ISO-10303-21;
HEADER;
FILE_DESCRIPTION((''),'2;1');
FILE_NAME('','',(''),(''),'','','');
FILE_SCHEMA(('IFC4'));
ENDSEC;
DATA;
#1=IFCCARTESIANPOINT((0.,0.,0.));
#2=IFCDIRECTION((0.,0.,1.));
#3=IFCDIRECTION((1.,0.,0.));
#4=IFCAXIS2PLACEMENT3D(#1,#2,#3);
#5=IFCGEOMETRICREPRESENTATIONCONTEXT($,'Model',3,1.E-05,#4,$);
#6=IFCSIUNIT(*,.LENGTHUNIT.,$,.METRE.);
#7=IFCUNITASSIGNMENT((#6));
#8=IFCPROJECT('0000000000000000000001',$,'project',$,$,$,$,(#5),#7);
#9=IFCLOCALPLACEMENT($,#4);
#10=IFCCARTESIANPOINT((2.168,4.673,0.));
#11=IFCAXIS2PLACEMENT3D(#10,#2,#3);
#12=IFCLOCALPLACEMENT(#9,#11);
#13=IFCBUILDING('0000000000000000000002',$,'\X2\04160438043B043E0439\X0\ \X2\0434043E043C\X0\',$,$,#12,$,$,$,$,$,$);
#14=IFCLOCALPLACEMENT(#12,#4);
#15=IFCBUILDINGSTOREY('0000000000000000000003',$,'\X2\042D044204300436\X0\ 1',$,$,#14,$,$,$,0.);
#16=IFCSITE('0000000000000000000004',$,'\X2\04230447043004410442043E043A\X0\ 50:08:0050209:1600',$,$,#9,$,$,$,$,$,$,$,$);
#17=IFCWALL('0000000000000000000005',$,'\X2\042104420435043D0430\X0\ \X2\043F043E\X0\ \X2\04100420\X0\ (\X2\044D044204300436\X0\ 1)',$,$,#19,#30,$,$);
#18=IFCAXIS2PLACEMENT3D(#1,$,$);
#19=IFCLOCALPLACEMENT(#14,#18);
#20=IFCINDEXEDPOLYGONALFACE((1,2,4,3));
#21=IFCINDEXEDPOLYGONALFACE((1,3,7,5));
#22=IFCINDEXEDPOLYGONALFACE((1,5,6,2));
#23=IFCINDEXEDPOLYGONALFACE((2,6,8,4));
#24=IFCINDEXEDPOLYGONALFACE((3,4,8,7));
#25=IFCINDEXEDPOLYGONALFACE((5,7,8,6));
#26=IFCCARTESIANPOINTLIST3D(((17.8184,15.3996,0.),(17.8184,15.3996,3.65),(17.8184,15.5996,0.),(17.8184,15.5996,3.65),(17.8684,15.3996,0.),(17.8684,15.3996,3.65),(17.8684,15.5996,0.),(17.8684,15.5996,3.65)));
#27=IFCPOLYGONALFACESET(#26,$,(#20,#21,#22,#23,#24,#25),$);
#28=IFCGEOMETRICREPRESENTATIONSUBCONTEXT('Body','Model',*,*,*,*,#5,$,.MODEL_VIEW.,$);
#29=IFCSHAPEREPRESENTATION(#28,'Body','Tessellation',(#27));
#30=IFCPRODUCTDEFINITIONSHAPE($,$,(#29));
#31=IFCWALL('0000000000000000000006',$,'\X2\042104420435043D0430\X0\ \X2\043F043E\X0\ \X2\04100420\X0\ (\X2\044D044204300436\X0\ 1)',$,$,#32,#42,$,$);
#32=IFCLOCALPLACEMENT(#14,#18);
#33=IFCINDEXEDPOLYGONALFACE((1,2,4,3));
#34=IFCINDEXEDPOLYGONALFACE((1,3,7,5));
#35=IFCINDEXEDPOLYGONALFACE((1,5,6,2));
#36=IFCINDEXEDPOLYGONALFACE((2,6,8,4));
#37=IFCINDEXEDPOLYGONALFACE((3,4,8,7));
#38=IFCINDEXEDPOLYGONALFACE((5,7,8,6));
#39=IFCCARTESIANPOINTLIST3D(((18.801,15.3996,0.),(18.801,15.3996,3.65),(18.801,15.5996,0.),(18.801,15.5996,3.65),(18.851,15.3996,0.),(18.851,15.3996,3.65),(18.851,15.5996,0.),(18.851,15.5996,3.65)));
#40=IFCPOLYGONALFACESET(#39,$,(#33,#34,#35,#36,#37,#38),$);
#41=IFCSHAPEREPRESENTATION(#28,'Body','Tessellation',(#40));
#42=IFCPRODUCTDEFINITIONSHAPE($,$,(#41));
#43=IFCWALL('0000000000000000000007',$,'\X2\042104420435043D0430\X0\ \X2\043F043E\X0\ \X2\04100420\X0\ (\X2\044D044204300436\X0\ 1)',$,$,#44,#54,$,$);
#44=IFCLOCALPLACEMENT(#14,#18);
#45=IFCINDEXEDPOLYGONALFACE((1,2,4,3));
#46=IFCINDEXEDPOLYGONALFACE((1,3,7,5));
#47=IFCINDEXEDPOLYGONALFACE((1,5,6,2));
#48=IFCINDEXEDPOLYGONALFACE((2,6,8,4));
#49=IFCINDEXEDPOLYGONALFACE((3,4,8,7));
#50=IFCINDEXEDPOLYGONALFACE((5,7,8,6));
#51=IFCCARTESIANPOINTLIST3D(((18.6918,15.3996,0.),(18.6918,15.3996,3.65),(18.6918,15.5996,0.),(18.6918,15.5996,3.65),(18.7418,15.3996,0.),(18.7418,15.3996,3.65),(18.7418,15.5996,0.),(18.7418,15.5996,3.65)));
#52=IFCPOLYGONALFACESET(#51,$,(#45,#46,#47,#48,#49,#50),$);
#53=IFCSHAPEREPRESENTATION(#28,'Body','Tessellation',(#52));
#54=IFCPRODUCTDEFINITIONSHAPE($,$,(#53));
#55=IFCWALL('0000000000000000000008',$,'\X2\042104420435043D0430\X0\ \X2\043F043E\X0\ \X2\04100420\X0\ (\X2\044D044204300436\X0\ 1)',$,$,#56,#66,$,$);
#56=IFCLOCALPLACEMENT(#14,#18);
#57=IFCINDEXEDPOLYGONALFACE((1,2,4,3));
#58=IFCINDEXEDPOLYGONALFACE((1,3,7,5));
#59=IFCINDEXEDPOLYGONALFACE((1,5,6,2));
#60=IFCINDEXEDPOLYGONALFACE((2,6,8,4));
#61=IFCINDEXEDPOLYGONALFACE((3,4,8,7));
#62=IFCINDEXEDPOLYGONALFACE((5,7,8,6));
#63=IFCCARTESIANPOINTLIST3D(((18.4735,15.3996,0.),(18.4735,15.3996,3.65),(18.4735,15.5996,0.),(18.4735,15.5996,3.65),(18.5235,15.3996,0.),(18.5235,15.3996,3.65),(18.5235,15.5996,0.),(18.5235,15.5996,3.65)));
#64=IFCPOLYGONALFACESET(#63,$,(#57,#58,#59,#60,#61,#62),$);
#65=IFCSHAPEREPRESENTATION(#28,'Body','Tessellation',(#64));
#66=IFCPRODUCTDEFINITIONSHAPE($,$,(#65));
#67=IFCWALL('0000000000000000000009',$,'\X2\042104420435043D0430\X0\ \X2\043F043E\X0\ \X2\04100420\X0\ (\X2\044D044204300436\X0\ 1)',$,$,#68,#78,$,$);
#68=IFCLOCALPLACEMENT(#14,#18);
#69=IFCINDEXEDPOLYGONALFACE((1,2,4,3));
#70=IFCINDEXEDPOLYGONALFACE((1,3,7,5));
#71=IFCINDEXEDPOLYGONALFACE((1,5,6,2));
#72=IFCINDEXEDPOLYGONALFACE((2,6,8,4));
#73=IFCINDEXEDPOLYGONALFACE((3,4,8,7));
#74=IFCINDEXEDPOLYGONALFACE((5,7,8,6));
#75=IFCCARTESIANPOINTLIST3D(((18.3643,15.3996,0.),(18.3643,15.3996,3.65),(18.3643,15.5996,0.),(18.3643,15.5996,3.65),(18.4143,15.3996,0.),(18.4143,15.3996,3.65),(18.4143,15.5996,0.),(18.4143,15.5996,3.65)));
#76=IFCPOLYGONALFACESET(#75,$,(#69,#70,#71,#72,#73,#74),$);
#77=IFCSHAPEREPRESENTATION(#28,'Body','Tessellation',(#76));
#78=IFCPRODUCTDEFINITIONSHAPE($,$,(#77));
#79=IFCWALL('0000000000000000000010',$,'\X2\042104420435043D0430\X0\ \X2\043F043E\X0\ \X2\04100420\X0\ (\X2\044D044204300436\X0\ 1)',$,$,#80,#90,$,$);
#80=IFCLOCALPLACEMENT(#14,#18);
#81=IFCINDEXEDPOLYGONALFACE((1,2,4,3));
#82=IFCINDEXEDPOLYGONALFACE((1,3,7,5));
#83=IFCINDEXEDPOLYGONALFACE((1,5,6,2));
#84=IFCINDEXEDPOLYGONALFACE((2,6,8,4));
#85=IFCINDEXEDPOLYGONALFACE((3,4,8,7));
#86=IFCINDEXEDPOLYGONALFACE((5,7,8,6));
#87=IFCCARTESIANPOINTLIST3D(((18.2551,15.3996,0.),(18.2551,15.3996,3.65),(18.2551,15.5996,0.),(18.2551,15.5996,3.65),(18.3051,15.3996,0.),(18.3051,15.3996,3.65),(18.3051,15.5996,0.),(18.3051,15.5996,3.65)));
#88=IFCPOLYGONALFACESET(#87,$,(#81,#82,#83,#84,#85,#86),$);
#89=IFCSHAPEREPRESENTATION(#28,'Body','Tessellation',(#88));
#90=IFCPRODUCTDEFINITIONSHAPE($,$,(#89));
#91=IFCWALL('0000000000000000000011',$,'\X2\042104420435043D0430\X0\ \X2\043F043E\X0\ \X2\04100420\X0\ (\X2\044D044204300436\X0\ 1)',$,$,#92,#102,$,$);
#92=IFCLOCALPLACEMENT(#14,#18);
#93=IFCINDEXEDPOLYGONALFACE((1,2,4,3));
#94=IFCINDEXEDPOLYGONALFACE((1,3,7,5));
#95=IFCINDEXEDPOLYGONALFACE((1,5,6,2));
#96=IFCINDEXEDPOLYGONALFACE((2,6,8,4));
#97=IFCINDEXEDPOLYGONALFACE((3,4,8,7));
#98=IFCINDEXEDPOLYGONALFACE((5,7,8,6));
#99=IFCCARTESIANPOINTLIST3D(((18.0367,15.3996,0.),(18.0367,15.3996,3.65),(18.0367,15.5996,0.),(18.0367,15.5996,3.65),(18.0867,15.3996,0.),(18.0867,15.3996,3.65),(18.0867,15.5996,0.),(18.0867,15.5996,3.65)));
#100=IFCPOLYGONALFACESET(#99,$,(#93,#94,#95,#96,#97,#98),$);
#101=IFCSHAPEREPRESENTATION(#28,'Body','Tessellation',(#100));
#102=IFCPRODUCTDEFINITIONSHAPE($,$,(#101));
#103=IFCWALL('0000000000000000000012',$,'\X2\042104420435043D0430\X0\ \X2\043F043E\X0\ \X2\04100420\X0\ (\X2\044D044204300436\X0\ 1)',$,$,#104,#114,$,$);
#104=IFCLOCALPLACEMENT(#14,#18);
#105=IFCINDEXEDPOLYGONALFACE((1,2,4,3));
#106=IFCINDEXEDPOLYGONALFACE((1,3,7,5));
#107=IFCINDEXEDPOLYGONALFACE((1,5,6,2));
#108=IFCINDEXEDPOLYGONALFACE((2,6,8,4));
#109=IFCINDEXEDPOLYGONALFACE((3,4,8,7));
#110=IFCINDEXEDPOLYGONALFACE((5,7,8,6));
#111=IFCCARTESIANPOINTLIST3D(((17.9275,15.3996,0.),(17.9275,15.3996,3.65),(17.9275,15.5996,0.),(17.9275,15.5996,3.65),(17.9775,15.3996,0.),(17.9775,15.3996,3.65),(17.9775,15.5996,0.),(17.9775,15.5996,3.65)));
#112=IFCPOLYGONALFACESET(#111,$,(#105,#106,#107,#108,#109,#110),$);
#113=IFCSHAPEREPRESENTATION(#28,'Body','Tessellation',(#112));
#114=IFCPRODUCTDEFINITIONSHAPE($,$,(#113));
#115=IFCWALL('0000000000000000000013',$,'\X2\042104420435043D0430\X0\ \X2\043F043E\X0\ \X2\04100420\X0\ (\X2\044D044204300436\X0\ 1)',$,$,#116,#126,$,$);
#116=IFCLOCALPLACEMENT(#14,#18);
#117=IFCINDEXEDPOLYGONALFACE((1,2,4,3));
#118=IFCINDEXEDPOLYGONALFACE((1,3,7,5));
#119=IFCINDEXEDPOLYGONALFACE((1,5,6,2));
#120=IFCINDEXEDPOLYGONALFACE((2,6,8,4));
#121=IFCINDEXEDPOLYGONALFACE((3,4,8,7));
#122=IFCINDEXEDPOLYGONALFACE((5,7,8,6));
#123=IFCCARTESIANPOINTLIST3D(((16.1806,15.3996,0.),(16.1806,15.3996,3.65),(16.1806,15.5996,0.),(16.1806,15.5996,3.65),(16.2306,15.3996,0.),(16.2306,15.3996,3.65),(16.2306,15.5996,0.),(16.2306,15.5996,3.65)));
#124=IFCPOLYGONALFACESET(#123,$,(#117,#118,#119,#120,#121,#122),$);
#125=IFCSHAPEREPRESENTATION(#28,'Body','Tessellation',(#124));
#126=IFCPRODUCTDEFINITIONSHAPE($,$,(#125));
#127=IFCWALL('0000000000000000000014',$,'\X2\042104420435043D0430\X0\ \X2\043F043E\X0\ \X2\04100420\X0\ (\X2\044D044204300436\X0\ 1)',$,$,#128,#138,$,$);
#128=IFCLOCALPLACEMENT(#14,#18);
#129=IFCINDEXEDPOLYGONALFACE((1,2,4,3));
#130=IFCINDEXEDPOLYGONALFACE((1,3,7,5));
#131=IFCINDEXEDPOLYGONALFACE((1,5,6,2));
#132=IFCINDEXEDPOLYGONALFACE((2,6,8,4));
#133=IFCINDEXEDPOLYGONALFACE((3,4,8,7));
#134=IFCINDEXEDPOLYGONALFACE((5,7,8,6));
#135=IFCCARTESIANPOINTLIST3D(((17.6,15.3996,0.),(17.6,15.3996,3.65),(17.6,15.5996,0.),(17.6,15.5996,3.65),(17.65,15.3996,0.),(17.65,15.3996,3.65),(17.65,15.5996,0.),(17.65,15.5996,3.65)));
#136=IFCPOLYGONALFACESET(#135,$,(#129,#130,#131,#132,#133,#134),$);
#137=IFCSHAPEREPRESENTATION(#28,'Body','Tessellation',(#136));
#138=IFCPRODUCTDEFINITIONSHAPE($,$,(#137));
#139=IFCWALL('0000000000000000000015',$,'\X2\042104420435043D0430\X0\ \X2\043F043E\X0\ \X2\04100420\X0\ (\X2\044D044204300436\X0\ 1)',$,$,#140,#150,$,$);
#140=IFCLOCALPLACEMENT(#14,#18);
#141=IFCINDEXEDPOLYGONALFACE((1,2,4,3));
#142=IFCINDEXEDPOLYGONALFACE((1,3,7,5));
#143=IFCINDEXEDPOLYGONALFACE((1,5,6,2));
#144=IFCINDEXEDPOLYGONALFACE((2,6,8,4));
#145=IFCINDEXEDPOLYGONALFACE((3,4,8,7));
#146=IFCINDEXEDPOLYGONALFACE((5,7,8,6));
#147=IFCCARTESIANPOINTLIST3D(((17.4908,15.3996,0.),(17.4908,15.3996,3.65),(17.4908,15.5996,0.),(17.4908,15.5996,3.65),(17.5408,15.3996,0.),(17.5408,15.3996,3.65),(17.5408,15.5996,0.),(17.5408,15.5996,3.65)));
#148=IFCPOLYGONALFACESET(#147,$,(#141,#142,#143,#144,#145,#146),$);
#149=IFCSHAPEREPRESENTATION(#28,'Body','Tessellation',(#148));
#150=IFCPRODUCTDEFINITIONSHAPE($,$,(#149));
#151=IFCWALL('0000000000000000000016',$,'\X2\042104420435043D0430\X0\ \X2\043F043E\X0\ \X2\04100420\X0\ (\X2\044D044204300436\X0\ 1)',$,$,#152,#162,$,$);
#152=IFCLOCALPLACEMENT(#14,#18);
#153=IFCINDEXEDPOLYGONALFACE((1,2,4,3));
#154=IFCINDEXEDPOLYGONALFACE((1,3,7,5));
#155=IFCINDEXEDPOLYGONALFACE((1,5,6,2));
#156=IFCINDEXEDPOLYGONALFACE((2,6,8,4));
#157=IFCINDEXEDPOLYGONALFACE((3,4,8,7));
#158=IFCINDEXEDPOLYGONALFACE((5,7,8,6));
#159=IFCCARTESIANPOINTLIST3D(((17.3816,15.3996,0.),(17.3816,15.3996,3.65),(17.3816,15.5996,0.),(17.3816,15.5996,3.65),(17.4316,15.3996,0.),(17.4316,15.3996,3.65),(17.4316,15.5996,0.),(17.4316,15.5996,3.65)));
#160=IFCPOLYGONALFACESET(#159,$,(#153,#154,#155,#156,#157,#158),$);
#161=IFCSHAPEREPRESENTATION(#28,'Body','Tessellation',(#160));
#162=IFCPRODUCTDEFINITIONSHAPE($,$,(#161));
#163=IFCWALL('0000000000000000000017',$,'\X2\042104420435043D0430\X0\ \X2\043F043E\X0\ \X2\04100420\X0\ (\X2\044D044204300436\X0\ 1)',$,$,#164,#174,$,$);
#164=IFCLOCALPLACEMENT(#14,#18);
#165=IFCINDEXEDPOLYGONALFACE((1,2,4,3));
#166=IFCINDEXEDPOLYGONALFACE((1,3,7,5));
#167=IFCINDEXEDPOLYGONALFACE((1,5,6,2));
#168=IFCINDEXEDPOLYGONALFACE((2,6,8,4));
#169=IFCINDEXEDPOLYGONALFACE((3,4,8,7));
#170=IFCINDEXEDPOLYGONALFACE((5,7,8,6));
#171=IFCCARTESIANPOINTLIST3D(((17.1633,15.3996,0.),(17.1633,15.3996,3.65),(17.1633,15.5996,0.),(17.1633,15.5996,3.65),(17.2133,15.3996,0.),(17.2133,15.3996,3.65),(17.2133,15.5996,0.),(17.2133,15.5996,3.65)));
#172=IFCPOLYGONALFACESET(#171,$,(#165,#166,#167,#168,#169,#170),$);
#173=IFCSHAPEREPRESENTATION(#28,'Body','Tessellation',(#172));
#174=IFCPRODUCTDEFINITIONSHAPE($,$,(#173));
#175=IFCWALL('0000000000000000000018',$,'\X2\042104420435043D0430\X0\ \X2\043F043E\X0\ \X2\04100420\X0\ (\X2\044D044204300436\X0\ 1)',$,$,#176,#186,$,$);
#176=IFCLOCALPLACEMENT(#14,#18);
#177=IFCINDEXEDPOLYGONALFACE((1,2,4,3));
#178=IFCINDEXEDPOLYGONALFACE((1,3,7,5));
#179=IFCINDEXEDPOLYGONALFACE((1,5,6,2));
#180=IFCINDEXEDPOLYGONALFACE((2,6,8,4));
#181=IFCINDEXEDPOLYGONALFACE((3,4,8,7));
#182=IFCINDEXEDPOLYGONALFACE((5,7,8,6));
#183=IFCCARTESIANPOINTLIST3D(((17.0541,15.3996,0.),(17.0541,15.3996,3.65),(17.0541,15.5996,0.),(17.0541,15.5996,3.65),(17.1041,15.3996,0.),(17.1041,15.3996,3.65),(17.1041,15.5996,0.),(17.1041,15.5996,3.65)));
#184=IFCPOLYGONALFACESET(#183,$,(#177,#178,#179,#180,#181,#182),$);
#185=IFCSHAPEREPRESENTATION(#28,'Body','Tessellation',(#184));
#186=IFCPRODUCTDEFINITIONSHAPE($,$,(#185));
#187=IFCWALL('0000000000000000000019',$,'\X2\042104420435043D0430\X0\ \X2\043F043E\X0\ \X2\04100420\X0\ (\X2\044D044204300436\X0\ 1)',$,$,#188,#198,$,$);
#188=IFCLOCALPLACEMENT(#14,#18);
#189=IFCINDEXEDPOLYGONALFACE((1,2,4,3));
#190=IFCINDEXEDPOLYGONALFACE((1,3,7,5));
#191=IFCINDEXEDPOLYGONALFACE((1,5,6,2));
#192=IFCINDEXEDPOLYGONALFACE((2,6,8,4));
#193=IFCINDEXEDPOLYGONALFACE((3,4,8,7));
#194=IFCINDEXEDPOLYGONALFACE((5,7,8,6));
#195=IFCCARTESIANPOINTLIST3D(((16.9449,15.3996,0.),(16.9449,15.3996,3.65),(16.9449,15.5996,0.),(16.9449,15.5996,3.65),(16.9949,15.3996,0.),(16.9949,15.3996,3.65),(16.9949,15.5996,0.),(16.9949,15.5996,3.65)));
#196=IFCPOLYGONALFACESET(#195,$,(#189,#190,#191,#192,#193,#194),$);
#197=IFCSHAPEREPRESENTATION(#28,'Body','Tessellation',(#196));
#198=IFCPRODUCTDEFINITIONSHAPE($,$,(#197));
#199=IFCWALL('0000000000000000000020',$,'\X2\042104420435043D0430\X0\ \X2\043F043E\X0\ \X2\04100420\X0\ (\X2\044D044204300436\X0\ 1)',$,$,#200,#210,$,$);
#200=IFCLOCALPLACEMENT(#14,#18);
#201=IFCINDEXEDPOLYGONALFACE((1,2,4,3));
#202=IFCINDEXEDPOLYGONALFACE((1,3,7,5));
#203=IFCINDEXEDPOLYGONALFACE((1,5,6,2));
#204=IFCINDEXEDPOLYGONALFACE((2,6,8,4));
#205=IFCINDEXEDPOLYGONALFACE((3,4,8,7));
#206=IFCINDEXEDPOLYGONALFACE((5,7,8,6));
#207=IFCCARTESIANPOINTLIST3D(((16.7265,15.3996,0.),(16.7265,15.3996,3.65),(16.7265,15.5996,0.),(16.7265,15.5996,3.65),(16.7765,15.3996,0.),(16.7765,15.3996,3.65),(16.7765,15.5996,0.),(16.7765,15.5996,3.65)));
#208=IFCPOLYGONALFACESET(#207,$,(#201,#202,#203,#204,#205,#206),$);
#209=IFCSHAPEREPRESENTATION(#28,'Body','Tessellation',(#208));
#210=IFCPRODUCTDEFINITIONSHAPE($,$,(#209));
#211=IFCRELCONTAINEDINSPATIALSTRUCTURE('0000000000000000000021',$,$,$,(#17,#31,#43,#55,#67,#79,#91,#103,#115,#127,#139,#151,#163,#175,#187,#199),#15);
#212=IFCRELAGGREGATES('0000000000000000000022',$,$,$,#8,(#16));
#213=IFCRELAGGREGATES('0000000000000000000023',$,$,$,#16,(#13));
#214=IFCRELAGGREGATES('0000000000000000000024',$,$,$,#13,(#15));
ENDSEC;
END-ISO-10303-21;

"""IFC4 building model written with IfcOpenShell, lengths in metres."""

from ifc_helpers import new_model, si_unit, frame, origin_with_axes, place, context, subcontext, project, spatial, polyline, outline, extrude, element, save


model = new_model("IFC4")

# Units and contexts
model_context = context("Model", 3, precision=1e-05, world=origin_with_axes())
body_context = subcontext(model_context, "Body", "Model", "MODEL_VIEW")
ifc_project = project(units=[si_unit("LENGTHUNIT", "METRE")], contexts=[model_context])

# Site, building, storey
site_placement = place(None, origin_with_axes())
site = spatial("IfcSite", under=ifc_project, at=site_placement, Name="Участок 50:08:0050209:1600")
building_placement = place(site_placement, frame((2.168, 4.673, 0.0), z_axis=(0.0, 0.0, 1.0), x_axis=(1.0, 0.0, 0.0)))
building = spatial("IfcBuilding", under=site, at=building_placement, Name="Жилой дом")
storey_placement = place(building_placement, origin_with_axes())
storey = spatial("IfcBuildingStorey", under=building, at=storey_placement, Name="Этаж 1", Elevation=0.0)

# Walls
wall_1_placement = place(storey_placement, origin_with_axes())
element("IfcWall", 1, at=wall_1_placement, inside=storey, Name="Стена по АР (этаж 1)", context=body_context, shape_type="SweptSolid", body=[
    extrude(outline(polyline([(17.8684, 15.5996), (17.8684, 15.3996), (17.8184, 15.3996), (17.8184, 15.5996), (17.8684, 15.5996)])), origin_with_axes(), (0.0, 0.0, 1.0), 3.65),
])
wall_2_placement = place(storey_placement, origin_with_axes())
element("IfcWall", 2, at=wall_2_placement, inside=storey, Name="Стена по АР (этаж 1)", context=body_context, shape_type="SweptSolid", body=[
    extrude(outline(polyline([(18.851, 15.5996), (18.851, 15.3996), (18.801, 15.3996), (18.801, 15.5996), (18.851, 15.5996)])), origin_with_axes(), (0.0, 0.0, 1.0), 3.65),
])
wall_3_placement = place(storey_placement, origin_with_axes())
element("IfcWall", 3, at=wall_3_placement, inside=storey, Name="Стена по АР (этаж 1)", context=body_context, shape_type="SweptSolid", body=[
    extrude(outline(polyline([(18.7418, 15.3996), (18.6918, 15.3996), (18.6918, 15.5996), (18.7418, 15.5996), (18.7418, 15.3996)])), origin_with_axes(), (0.0, 0.0, 1.0), 3.65),
])
wall_4_placement = place(storey_placement, origin_with_axes())
element("IfcWall", 4, at=wall_4_placement, inside=storey, Name="Стена по АР (этаж 1)", context=body_context, shape_type="SweptSolid", body=[
    extrude(outline(polyline([(18.5235, 15.3996), (18.4735, 15.3996), (18.4735, 15.5996), (18.5235, 15.5996), (18.5235, 15.3996)])), origin_with_axes(), (0.0, 0.0, 1.0), 3.65),
])
wall_5_placement = place(storey_placement, origin_with_axes())
element("IfcWall", 5, at=wall_5_placement, inside=storey, Name="Стена по АР (этаж 1)", context=body_context, shape_type="SweptSolid", body=[
    extrude(outline(polyline([(18.4143, 15.5996), (18.4143, 15.3996), (18.3643, 15.3996), (18.3643, 15.5996), (18.4143, 15.5996)])), origin_with_axes(), (0.0, 0.0, 1.0), 3.65),
])
wall_6_placement = place(storey_placement, origin_with_axes())
element("IfcWall", 6, at=wall_6_placement, inside=storey, Name="Стена по АР (этаж 1)", context=body_context, shape_type="SweptSolid", body=[
    extrude(outline(polyline([(18.3051, 15.3996), (18.2551, 15.3996), (18.2551, 15.5996), (18.3051, 15.5996), (18.3051, 15.3996)])), origin_with_axes(), (0.0, 0.0, 1.0), 3.65),
])
wall_7_placement = place(storey_placement, origin_with_axes())
element("IfcWall", 7, at=wall_7_placement, inside=storey, Name="Стена по АР (этаж 1)", context=body_context, shape_type="SweptSolid", body=[
    extrude(outline(polyline([(18.0867, 15.3996), (18.0367, 15.3996), (18.0367, 15.5996), (18.0867, 15.5996), (18.0867, 15.3996)])), origin_with_axes(), (0.0, 0.0, 1.0), 3.65),
])
wall_8_placement = place(storey_placement, origin_with_axes())
element("IfcWall", 8, at=wall_8_placement, inside=storey, Name="Стена по АР (этаж 1)", context=body_context, shape_type="SweptSolid", body=[
    extrude(outline(polyline([(17.9775, 15.5996), (17.9775, 15.3996), (17.9275, 15.3996), (17.9275, 15.5996), (17.9775, 15.5996)])), origin_with_axes(), (0.0, 0.0, 1.0), 3.65),
])
wall_9_placement = place(storey_placement, origin_with_axes())
element("IfcWall", 9, at=wall_9_placement, inside=storey, Name="Стена по АР (этаж 1)", context=body_context, shape_type="SweptSolid", body=[
    extrude(outline(polyline([(16.2306, 15.3996), (16.1806, 15.3996), (16.1806, 15.5996), (16.2306, 15.5996), (16.2306, 15.3996)])), origin_with_axes(), (0.0, 0.0, 1.0), 3.65),
])
wall_10_placement = place(storey_placement, origin_with_axes())
element("IfcWall", 10, at=wall_10_placement, inside=storey, Name="Стена по АР (этаж 1)", context=body_context, shape_type="SweptSolid", body=[
    extrude(outline(polyline([(17.65, 15.3996), (17.6, 15.3996), (17.6, 15.5996), (17.65, 15.5996), (17.65, 15.3996)])), origin_with_axes(), (0.0, 0.0, 1.0), 3.65),
])
wall_11_placement = place(storey_placement, origin_with_axes())
element("IfcWall", 11, at=wall_11_placement, inside=storey, Name="Стена по АР (этаж 1)", context=body_context, shape_type="SweptSolid", body=[
    extrude(outline(polyline([(17.5408, 15.5996), (17.5408, 15.3996), (17.4908, 15.3996), (17.4908, 15.5996), (17.5408, 15.5996)])), origin_with_axes(), (0.0, 0.0, 1.0), 3.65),
])
wall_12_placement = place(storey_placement, origin_with_axes())
element("IfcWall", 12, at=wall_12_placement, inside=storey, Name="Стена по АР (этаж 1)", context=body_context, shape_type="SweptSolid", body=[
    extrude(outline(polyline([(17.4316, 15.5996), (17.4316, 15.3996), (17.3816, 15.3996), (17.3816, 15.5996), (17.4316, 15.5996)])), origin_with_axes(), (0.0, 0.0, 1.0), 3.65),
])
wall_13_placement = place(storey_placement, origin_with_axes())
element("IfcWall", 13, at=wall_13_placement, inside=storey, Name="Стена по АР (этаж 1)", context=body_context, shape_type="SweptSolid", body=[
    extrude(outline(polyline([(17.2133, 15.5996), (17.2133, 15.3996), (17.1633, 15.3996), (17.1633, 15.5996), (17.2133, 15.5996)])), origin_with_axes(), (0.0, 0.0, 1.0), 3.65),
])
wall_14_placement = place(storey_placement, origin_with_axes())
element("IfcWall", 14, at=wall_14_placement, inside=storey, Name="Стена по АР (этаж 1)", context=body_context, shape_type="SweptSolid", body=[
    extrude(outline(polyline([(17.1041, 15.3996), (17.0541, 15.3996), (17.0541, 15.5996), (17.1041, 15.5996), (17.1041, 15.3996)])), origin_with_axes(), (0.0, 0.0, 1.0), 3.65),
])
wall_15_placement = place(storey_placement, origin_with_axes())
element("IfcWall", 15, at=wall_15_placement, inside=storey, Name="Стена по АР (этаж 1)", context=body_context, shape_type="SweptSolid", body=[
    extrude(outline(polyline([(16.9949, 15.3996), (16.9449, 15.3996), (16.9449, 15.5996), (16.9949, 15.5996), (16.9949, 15.3996)])), origin_with_axes(), (0.0, 0.0, 1.0), 3.65),
])
wall_16_placement = place(storey_placement, origin_with_axes())
element("IfcWall", 16, at=wall_16_placement, inside=storey, Name="Стена по АР (этаж 1)", context=body_context, shape_type="SweptSolid", body=[
    extrude(outline(polyline([(16.7765, 15.5996), (16.7765, 15.3996), (16.7265, 15.3996), (16.7265, 15.5996), (16.7765, 15.5996)])), origin_with_axes(), (0.0, 0.0, 1.0), 3.65),
])

save(model, "model.ifc")
